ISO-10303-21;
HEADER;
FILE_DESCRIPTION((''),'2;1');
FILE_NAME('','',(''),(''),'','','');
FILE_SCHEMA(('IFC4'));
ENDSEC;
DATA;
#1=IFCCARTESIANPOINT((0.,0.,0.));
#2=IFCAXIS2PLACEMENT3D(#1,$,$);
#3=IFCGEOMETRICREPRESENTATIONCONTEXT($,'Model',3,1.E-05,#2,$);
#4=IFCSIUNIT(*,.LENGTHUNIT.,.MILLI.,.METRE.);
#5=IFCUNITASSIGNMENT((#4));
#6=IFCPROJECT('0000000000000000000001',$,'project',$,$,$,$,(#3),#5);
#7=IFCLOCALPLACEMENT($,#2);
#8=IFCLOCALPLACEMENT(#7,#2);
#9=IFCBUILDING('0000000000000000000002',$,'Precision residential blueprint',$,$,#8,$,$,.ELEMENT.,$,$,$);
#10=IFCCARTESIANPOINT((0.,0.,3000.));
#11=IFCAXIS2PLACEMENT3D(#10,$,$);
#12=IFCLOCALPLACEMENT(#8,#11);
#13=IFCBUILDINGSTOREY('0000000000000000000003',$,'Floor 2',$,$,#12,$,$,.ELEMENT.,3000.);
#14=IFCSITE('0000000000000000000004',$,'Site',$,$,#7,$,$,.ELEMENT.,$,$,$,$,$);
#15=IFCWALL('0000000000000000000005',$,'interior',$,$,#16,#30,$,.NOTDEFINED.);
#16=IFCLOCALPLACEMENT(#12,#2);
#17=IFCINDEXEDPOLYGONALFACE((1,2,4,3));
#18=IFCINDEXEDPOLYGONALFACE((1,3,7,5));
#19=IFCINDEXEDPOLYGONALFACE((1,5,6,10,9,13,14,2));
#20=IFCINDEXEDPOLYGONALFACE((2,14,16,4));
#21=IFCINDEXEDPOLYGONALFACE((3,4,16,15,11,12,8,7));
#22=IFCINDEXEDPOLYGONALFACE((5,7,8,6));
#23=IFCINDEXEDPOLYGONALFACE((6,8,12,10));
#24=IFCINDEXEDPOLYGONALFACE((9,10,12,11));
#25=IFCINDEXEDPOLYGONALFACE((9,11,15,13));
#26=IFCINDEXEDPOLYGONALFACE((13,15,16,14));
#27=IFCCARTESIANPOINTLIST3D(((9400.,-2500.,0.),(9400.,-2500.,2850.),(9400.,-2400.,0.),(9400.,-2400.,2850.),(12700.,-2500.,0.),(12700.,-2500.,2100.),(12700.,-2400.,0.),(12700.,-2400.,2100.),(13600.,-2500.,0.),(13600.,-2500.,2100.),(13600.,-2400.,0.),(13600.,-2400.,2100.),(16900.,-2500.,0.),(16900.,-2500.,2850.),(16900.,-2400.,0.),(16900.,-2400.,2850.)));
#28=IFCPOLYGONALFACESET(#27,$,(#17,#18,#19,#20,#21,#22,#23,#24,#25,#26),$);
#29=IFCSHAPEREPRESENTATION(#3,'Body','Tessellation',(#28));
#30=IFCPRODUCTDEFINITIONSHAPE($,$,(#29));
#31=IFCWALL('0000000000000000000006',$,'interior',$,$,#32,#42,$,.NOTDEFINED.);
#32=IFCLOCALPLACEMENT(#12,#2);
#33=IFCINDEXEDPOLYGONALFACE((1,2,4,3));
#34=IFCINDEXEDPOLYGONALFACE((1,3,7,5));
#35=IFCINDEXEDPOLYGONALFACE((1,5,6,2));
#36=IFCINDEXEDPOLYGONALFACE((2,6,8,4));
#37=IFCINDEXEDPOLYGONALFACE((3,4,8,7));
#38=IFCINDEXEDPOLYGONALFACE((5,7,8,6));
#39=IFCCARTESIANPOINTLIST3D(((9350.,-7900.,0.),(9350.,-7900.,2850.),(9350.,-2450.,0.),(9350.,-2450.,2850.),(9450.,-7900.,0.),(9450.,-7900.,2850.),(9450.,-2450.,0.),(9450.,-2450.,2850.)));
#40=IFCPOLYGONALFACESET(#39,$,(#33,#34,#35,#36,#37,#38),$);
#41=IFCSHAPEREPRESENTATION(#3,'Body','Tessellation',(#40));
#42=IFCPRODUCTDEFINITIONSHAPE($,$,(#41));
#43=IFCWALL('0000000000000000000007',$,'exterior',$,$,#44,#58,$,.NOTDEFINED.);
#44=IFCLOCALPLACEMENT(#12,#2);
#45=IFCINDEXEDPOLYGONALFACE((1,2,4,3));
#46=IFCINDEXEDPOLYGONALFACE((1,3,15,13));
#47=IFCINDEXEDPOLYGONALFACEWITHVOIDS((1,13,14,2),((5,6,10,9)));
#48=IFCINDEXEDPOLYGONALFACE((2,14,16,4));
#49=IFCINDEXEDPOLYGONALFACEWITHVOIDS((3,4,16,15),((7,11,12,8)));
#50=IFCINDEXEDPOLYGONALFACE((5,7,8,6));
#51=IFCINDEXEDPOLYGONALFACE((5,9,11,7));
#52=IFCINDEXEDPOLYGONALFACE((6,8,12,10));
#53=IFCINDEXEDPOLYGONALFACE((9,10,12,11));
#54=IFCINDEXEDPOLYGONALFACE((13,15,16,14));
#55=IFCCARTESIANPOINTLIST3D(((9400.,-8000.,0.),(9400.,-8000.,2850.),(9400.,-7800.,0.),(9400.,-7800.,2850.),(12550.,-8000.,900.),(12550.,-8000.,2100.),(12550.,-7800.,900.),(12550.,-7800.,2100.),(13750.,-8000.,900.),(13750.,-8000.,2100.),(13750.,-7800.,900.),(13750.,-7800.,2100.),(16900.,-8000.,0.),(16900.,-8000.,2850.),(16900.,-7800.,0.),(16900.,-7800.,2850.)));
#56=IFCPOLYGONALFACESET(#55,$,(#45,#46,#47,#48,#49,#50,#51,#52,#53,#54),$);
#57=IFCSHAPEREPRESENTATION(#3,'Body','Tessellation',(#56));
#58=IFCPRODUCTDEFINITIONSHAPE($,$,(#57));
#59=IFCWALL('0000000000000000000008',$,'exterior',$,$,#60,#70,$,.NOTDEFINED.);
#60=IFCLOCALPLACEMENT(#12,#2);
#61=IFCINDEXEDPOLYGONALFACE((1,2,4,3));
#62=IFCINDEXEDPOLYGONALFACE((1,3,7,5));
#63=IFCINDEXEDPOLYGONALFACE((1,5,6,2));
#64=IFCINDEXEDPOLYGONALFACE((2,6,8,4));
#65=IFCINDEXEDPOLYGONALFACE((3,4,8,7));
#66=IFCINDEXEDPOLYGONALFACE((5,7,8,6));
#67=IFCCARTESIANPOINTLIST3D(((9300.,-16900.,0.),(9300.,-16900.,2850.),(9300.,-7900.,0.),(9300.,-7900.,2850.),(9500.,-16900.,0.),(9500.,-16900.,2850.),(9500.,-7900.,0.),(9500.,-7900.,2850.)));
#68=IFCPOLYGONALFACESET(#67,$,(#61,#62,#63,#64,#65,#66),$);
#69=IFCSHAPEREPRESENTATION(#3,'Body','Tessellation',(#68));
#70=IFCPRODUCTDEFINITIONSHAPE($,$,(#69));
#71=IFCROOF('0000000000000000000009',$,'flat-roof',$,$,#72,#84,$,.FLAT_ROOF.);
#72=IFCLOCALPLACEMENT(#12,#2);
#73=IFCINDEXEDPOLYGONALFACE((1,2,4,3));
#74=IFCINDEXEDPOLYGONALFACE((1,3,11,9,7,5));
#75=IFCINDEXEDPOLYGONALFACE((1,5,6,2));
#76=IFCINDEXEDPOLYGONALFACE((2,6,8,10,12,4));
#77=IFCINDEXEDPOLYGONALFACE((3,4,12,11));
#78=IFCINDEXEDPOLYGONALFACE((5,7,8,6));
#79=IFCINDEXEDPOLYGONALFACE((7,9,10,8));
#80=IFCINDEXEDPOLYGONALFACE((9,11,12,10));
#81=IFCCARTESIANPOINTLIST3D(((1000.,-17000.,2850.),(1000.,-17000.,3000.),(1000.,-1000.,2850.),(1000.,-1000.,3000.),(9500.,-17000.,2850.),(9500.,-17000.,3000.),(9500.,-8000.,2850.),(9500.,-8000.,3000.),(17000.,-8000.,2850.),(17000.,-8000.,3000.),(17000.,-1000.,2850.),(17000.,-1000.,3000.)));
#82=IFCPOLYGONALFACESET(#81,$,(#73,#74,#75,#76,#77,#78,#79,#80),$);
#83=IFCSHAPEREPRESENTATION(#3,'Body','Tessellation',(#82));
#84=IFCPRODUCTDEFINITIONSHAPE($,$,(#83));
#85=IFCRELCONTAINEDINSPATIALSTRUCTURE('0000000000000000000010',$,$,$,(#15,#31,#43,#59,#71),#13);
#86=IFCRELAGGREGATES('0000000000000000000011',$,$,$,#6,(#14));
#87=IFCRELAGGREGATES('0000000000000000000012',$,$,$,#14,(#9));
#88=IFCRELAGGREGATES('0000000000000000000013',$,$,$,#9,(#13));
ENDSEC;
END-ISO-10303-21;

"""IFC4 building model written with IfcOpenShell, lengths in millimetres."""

from ifc_helpers import new_model, si_unit, frame, origin, place, context, project, spatial, polyline, outline, extrude, element, save


model = new_model("IFC4")

# Units and contexts
model_context = context("Model", 3, precision=1e-05, world=origin())
ifc_project = project(units=[si_unit("LENGTHUNIT", "METRE", prefix="MILLI")], contexts=[model_context])

# Site, building, storey
site_placement = place(None, origin())
site = spatial("IfcSite", under=ifc_project, at=site_placement, Name="Site", CompositionType="ELEMENT")
building_placement = place(site_placement, origin())
building = spatial("IfcBuilding", under=site, at=building_placement, Name="Precision residential blueprint", CompositionType="ELEMENT")
storey_placement = place(building_placement, frame((0.0, 0.0, 3000.0)))
storey = spatial("IfcBuildingStorey", under=building, at=storey_placement, Name="Floor 2", CompositionType="ELEMENT", Elevation=3000.0)

# Wall, opening
wall_1_placement = place(storey_placement, origin())
wall_1 = element("IfcWall", 1, at=wall_1_placement, inside=storey, Name="interior", PredefinedType="NOTDEFINED", context=model_context, shape_type="SweptSolid", body=[
    extrude(outline(polyline([(9400.0, -2400.0), (16900.0, -2400.0), (16900.0, -2500.0), (9400.0, -2500.0), (9400.0, -2400.0)])), origin(), (0.0, 0.0, 1.0), 2850.0),
])
opening_1_placement = place(storey_placement, origin())
element("IfcOpeningElement", 2, at=opening_1_placement, cuts=wall_1, PredefinedType="OPENING", context=model_context, shape_type="SweptSolid", body=[
    extrude(outline(polyline([(12700.0, -2400.0), (13600.0, -2400.0), (13600.0, -2500.0), (12700.0, -2500.0), (12700.0, -2400.0)])), origin(), (0.0, 0.0, 1.0), 2100.0),
])

# Wall
wall_2_placement = place(storey_placement, origin())
element("IfcWall", 3, at=wall_2_placement, inside=storey, Name="interior", PredefinedType="NOTDEFINED", context=model_context, shape_type="SweptSolid", body=[
    extrude(outline(polyline([(9450.0, -2450.0), (9450.0, -7900.0), (9350.0, -7900.0), (9350.0, -2450.0), (9450.0, -2450.0)])), origin(), (0.0, 0.0, 1.0), 2850.0),
])

# Wall, opening
wall_3_placement = place(storey_placement, origin())
wall_3 = element("IfcWall", 4, at=wall_3_placement, inside=storey, Name="exterior", PredefinedType="NOTDEFINED", context=model_context, shape_type="SweptSolid", body=[
    extrude(outline(polyline([(9400.0, -7800.0), (16900.0, -7800.0), (16900.0, -8000.0), (9400.0, -8000.0), (9400.0, -7800.0)])), origin(), (0.0, 0.0, 1.0), 2850.0),
])
opening_2_placement = place(storey_placement, origin())
element("IfcOpeningElement", 5, at=opening_2_placement, cuts=wall_3, PredefinedType="OPENING", context=model_context, shape_type="SweptSolid", body=[
    extrude(outline(polyline([(12550.0, -7800.0), (13750.0, -7800.0), (13750.0, -8000.0), (12550.0, -8000.0), (12550.0, -7800.0)])), frame((0.0, 0.0, 900.0)), (0.0, 0.0, 1.0), 1200.0),
])

# Wall
wall_4_placement = place(storey_placement, origin())
element("IfcWall", 6, at=wall_4_placement, inside=storey, Name="exterior", PredefinedType="NOTDEFINED", context=model_context, shape_type="SweptSolid", body=[
    extrude(outline(polyline([(9500.0, -7900.0), (9500.0, -16900.0), (9300.0, -16900.0), (9300.0, -7900.0), (9500.0, -7900.0)])), origin(), (0.0, 0.0, 1.0), 2850.0),
])

# Roof
roof_placement = place(storey_placement, origin())
element("IfcRoof", 7, at=roof_placement, inside=storey, Name="flat-roof", PredefinedType="FLAT_ROOF", context=model_context, shape_type="SweptSolid", body=[
    extrude(outline(polyline([(1000.0, -17000.0), (9500.0, -17000.0), (9500.0, -8000.0), (17000.0, -8000.0), (17000.0, -1000.0), (1000.0, -1000.0), (1000.0, -17000.0)])), frame((0.0, 0.0, 2850.0)), (0.0, 0.0, 1.0), 150.0),
])

save(model, "model.ifc")
